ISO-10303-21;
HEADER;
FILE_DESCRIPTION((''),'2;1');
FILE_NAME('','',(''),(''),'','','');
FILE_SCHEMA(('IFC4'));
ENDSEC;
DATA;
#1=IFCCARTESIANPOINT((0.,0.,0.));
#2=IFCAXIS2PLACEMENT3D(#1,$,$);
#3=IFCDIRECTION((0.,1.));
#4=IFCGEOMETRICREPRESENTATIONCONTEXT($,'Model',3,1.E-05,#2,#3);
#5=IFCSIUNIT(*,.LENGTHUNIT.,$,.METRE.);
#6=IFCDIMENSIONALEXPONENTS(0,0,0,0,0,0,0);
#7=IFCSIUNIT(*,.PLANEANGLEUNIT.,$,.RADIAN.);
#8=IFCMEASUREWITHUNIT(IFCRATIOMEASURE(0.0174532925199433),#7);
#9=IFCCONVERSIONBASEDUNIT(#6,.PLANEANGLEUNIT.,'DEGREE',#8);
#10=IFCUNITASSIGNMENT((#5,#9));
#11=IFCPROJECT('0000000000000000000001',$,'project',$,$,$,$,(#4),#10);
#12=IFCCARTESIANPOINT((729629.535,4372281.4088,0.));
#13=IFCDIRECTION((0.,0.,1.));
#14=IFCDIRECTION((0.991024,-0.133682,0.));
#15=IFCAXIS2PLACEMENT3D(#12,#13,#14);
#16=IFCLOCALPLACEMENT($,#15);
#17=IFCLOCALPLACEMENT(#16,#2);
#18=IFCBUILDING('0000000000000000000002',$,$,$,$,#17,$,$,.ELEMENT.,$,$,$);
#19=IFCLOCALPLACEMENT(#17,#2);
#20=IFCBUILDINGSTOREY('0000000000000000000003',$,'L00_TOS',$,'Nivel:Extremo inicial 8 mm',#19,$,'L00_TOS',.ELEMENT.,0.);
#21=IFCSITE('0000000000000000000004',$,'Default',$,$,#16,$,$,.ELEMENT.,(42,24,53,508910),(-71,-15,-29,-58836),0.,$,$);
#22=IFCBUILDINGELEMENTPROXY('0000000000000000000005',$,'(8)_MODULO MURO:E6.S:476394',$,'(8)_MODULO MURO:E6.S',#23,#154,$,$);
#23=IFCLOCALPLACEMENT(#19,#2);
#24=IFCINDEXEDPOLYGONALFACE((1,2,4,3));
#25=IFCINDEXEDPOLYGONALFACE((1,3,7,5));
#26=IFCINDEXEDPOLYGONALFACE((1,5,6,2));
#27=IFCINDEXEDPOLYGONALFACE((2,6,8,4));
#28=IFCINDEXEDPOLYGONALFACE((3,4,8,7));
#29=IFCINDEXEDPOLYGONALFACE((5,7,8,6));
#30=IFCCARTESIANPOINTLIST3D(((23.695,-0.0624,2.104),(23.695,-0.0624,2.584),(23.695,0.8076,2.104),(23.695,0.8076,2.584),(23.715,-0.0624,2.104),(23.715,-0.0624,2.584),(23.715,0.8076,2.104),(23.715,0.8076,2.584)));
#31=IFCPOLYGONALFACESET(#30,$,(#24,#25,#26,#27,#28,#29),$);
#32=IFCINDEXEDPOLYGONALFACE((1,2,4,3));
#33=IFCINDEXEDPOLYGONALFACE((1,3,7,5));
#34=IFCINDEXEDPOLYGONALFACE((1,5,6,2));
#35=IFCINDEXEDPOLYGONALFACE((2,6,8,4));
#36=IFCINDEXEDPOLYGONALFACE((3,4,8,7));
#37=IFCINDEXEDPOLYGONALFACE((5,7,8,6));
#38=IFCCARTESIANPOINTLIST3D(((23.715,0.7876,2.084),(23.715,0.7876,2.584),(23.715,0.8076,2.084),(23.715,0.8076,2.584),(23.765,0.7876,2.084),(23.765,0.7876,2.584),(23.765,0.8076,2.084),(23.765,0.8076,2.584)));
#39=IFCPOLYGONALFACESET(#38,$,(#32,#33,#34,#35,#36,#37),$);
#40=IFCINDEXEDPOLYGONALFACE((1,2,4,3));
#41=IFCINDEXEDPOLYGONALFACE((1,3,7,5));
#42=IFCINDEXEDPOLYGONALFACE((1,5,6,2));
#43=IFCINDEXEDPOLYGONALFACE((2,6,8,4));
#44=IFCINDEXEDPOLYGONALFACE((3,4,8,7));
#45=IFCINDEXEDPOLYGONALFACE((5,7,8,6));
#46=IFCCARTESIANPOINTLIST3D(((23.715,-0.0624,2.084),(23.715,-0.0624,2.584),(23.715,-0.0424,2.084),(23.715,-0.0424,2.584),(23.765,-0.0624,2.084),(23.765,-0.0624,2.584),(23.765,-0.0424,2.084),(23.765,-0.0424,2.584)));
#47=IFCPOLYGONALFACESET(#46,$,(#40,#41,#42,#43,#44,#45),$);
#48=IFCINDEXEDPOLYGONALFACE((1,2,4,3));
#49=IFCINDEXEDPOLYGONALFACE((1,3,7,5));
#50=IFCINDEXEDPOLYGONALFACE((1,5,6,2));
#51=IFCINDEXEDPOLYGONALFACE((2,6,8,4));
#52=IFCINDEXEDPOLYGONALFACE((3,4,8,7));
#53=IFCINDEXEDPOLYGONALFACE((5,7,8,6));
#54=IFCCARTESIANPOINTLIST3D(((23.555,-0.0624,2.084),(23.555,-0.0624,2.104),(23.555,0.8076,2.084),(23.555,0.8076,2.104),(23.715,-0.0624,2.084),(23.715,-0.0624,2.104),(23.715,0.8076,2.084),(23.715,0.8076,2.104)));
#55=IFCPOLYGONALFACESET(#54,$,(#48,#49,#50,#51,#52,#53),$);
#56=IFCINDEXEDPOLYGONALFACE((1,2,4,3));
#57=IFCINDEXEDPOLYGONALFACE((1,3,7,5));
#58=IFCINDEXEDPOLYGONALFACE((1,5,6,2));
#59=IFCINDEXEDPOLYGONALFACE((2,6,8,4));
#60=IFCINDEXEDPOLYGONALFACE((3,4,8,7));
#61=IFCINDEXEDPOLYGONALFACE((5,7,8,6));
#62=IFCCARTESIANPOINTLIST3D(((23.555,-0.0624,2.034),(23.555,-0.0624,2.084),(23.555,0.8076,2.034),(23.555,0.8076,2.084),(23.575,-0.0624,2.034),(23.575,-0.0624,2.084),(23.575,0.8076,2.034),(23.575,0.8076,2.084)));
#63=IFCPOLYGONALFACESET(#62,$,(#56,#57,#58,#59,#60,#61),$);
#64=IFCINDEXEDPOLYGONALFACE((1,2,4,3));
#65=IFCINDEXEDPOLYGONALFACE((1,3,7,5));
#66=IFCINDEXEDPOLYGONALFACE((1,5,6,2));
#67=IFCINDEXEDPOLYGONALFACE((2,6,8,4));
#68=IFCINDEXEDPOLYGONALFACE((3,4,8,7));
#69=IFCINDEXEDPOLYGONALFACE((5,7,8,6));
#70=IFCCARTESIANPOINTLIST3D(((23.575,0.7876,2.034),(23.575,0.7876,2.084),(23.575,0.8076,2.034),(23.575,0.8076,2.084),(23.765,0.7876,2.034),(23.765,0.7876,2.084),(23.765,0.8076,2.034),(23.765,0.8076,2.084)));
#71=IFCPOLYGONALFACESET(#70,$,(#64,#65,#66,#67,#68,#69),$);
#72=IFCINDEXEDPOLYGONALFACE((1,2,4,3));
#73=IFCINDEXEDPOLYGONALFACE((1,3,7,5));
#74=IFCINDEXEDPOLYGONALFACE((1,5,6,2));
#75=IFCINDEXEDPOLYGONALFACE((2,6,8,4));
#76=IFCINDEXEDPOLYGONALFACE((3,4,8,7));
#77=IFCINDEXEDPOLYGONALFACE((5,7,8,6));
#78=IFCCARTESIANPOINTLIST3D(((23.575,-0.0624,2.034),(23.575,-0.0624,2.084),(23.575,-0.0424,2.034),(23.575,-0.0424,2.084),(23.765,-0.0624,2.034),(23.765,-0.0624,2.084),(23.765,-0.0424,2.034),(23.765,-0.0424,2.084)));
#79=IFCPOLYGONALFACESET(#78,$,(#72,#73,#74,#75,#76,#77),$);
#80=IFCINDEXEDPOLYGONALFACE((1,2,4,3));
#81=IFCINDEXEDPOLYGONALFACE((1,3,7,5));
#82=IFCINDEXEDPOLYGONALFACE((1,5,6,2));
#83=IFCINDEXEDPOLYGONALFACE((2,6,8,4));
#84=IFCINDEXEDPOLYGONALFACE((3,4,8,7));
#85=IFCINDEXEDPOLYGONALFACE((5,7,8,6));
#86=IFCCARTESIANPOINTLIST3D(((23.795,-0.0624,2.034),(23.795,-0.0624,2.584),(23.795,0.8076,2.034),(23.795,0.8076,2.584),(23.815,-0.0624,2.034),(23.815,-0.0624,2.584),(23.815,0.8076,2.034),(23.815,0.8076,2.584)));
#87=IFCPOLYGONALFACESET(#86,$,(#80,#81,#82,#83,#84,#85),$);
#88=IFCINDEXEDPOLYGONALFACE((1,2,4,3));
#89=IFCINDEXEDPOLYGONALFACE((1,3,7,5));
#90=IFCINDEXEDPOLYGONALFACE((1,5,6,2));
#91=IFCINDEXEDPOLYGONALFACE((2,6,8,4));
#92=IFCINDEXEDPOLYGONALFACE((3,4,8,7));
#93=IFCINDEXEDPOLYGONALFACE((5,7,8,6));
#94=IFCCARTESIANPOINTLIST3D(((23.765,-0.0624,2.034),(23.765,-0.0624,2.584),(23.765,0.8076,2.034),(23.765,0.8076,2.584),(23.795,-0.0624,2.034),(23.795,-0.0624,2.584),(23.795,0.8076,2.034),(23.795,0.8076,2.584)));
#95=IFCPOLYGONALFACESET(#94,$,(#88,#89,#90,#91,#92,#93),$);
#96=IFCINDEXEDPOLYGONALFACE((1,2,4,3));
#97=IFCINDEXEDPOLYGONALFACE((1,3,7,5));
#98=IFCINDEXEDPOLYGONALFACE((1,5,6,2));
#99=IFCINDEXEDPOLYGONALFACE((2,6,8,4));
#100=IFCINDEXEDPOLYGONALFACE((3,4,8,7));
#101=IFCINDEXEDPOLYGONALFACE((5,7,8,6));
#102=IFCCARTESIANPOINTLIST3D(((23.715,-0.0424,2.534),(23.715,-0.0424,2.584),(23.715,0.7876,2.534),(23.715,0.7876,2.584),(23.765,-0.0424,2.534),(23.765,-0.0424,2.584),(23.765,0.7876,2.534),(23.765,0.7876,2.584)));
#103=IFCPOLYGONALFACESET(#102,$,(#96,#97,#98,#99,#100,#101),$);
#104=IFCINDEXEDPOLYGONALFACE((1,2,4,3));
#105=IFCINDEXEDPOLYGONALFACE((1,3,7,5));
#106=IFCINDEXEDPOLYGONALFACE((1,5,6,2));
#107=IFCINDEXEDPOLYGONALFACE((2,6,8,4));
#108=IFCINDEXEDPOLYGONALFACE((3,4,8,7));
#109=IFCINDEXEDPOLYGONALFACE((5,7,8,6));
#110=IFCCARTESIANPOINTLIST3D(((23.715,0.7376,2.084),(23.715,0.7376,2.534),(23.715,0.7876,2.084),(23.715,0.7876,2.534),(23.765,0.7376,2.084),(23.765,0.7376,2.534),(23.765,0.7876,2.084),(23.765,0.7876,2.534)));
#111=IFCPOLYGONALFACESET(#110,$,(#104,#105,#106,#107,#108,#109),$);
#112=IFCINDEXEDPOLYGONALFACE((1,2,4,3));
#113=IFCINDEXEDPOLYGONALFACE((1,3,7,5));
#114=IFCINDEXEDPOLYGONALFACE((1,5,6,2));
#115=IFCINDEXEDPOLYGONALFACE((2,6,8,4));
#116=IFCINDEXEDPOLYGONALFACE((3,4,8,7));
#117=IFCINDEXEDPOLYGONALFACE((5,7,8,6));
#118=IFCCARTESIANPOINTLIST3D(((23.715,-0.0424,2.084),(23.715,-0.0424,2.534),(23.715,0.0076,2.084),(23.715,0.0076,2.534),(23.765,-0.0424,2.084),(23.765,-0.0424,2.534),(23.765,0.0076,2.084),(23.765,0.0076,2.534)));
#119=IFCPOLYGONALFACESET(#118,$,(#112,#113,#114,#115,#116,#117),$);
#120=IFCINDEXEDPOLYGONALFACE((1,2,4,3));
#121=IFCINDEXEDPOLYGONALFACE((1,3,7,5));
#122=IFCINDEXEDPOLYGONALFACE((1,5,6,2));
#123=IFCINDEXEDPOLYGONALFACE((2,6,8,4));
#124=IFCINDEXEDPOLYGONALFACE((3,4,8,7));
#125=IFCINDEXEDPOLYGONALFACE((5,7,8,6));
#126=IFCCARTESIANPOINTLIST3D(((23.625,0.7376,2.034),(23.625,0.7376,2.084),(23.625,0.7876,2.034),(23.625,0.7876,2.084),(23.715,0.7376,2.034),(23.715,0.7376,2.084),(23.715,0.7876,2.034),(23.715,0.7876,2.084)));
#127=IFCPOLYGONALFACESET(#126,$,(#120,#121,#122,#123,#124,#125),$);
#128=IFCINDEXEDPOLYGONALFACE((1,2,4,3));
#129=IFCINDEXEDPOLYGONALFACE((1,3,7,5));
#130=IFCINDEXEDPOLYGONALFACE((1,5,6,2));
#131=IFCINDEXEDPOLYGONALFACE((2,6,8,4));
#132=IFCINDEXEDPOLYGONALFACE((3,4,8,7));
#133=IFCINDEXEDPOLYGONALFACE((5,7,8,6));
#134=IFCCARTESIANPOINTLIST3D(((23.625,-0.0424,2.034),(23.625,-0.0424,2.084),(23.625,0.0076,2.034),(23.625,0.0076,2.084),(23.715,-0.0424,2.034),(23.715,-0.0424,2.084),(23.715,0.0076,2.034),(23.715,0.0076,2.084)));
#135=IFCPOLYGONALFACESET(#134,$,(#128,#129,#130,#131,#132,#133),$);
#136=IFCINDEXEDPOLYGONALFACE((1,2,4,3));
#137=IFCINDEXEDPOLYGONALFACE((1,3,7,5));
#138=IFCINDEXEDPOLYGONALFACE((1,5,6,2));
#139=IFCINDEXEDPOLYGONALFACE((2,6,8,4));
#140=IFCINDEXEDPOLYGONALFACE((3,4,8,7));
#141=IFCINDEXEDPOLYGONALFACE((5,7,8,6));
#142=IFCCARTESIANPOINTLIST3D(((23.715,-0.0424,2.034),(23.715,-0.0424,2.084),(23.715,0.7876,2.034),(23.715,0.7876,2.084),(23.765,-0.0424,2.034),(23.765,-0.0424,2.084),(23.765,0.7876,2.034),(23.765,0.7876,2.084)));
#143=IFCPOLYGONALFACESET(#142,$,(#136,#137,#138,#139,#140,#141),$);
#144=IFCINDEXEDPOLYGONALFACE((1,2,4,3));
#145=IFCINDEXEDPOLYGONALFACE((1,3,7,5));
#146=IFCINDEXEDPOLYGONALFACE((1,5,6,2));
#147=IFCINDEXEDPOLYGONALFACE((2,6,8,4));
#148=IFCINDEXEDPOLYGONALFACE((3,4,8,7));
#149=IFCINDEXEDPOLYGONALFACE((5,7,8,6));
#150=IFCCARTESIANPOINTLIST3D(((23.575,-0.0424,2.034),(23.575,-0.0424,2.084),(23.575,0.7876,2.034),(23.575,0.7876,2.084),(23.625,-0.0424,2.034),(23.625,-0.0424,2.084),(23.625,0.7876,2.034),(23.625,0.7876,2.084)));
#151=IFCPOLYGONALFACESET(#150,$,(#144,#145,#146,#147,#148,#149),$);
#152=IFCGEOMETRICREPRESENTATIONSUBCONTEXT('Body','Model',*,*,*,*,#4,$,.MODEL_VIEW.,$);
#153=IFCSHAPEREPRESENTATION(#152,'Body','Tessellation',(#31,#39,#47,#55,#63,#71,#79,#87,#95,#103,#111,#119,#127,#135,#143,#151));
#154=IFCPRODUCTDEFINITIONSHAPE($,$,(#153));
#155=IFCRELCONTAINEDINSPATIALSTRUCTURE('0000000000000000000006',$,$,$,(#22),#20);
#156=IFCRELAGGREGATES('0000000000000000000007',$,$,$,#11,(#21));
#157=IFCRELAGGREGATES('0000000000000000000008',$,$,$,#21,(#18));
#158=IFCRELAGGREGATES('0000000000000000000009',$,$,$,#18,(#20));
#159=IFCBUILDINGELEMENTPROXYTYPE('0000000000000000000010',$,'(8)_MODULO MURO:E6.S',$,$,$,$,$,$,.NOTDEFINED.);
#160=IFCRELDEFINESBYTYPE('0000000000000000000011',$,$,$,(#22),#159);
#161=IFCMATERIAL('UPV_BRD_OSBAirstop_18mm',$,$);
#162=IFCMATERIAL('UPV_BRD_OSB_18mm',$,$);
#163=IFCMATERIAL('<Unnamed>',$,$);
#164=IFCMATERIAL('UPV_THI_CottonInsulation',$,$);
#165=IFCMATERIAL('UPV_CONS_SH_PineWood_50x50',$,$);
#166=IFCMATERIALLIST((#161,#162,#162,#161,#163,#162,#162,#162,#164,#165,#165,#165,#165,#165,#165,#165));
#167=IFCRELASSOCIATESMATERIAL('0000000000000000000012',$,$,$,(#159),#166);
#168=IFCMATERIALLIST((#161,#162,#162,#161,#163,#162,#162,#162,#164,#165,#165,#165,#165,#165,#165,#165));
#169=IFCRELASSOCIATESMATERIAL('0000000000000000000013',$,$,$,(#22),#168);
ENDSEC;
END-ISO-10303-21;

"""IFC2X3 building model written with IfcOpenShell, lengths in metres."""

from ifc_helpers import new_model, entity, si_unit, converted_unit, direction, frame, frame_2d, origin, origin_2d_with_axis, place, context, subcontext, project, spatial, rectangle, extrude, source, transform, mapped, material, material_list, type_object, type_shapes, element, save


model = new_model("IFC2X3")

# Units and contexts
model_context = context("Model", 3, precision=1e-05, world=origin(), true_north=direction((0.0, 1.0)))
body_context = subcontext(model_context, "Body", "Model", "MODEL_VIEW")
ifc_project = project(units=[si_unit("LENGTHUNIT", "METRE"), converted_unit("PLANEANGLEUNIT", "DEGREE", entity("IfcRatioMeasure", 0.0174532925199433), si_unit("PLANEANGLEUNIT", "RADIAN"), dimensions=[0, 0, 0, 0, 0, 0, 0])], contexts=[model_context])

# Site, building, storey
site_placement = place(None, frame((729629.535, 4372281.4088, 0.0), z_axis=(0.0, 0.0, 1.0), x_axis=(0.991024, -0.133682, 0.0)))
site = spatial("IfcSite", under=ifc_project, at=site_placement, Name="Default", CompositionType="ELEMENT", RefLatitude=(42, 24, 53, 508910), RefLongitude=(-71, -15, -29, -58836), RefElevation=0.0)
building_placement = place(site_placement, origin())
building = spatial("IfcBuilding", under=site, at=building_placement, CompositionType="ELEMENT")
storey_placement = place(building_placement, origin())
storey = spatial("IfcBuildingStorey", under=building, at=storey_placement, Name="L00_TOS", ObjectType="Nivel:Extremo inicial 8 mm", LongName="L00_TOS", CompositionType="ELEMENT", Elevation=0.0)

# Building element proxy
ifc_material_1 = material(Name="UPV_BRD_OSBAirstop_18mm")
ifc_material_2 = material(Name="UPV_BRD_OSB_18mm")
ifc_material_3 = material(Name="UPV_THI_CottonInsulation")
ifc_material_4 = material(Name="<Unnamed>")
ifc_material_5 = material(Name="UPV_CONS_SH_PineWood_50x50")
ifc_material_list_1 = material_list([ifc_material_1, ifc_material_2, ifc_material_2, ifc_material_1, ifc_material_4, ifc_material_2, ifc_material_2, ifc_material_2, ifc_material_3, ifc_material_5, ifc_material_5, ifc_material_5, ifc_material_5, ifc_material_5, ifc_material_5, ifc_material_5])
ifc_material_list_2 = material_list([ifc_material_1, ifc_material_2, ifc_material_2, ifc_material_1, ifc_material_4, ifc_material_2, ifc_material_2, ifc_material_2, ifc_material_3, ifc_material_5, ifc_material_5, ifc_material_5, ifc_material_5, ifc_material_5, ifc_material_5, ifc_material_5])
building_element_proxy_type_1 = type_object("IfcBuildingElementProxyType", Name="(8)_MODULO MURO:E6.S", PredefinedType="NOTDEFINED", material=ifc_material_list_2)
shared_shape_1 = source(origin(), body_context, "Body", "SweptSolid", [
    extrude(rectangle(XDim=0.87, YDim=0.02, at=frame_2d((0.0, 0.0), x_axis=(1.0, 0.0))), frame((0.0, 0.035, 0.07), z_axis=(0.0, 0.0, 1.0), x_axis=(-1.0, 0.0, 0.0)), (0.0, 0.0, 1.0), 0.48),
    extrude(rectangle(XDim=0.05, YDim=0.02, at=frame_2d((0.0, 0.0), x_axis=(1.0, 0.0))), frame((-0.425, 0.07, 0.05), z_axis=(0.0, 0.0, 1.0), x_axis=(0.0, -1.0, 0.0)), (0.0, 0.0, 1.0), 0.5),
    extrude(rectangle(XDim=0.05, YDim=0.02, at=origin_2d_with_axis()), frame((0.425, 0.07, 0.05), z_axis=(0.0, 0.0, 1.0), x_axis=(0.0, -1.0, 0.0)), (0.0, 0.0, 1.0), 0.5),
    extrude(rectangle(XDim=0.87, YDim=0.16, at=origin_2d_with_axis()), frame((0.0, -0.035, 0.05)), (0.0, 0.0, 1.0), 0.02),
    extrude(rectangle(XDim=0.87, YDim=0.02, at=origin_2d_with_axis()), frame((0.0, -0.105, 0.0), z_axis=(0.0, 0.0, 1.0), x_axis=(-1.0, 0.0, 0.0)), (0.0, 0.0, 1.0), 0.05),
    extrude(rectangle(XDim=0.19, YDim=0.02, at=frame_2d((0.0, 0.0), x_axis=(1.0, 0.0))), frame((-0.425, 0.0, 0.0), z_axis=(0.0, 0.0, 1.0), x_axis=(0.0, -1.0, 0.0)), (0.0, 0.0, 1.0), 0.05),
    extrude(rectangle(XDim=0.19, YDim=0.02, at=origin_2d_with_axis()), frame((0.425, 0.0, 0.0), z_axis=(0.0, 0.0, 1.0), x_axis=(0.0, -1.0, 0.0)), (0.0, 0.0, 1.0), 0.05),
    extrude(rectangle(XDim=0.87, YDim=0.02, at=frame_2d((0.0, 0.0), x_axis=(1.0, 0.0))), frame((0.0, 0.135, 0.0), z_axis=(0.0, 0.0, 1.0), x_axis=(-1.0, 0.0, 0.0)), (0.0, 0.0, 1.0), 0.55),
    extrude(rectangle(XDim=0.87, YDim=0.03, at=origin_2d_with_axis()), frame((0.0, 0.11, 0.0)), (0.0, 0.0, 1.0), 0.55),
    extrude(rectangle(XDim=0.05, YDim=0.83, at=origin_2d_with_axis()), frame((0.0, 0.07, 0.5), z_axis=(0.0, 0.0, 1.0), x_axis=(0.0, -1.0, 0.0)), (0.0, 0.0, 1.0), 0.05),
    extrude(rectangle(XDim=0.05, YDim=0.05, at=origin_2d_with_axis()), frame((-0.39, 0.07, 0.05)), (0.0, 0.0, 1.0), 0.45),
    extrude(rectangle(XDim=0.05, YDim=0.05, at=origin_2d_with_axis()), frame((0.39, 0.07, 0.05), z_axis=(0.0, 0.0, 1.0), x_axis=(0.0, -1.0, 0.0)), (0.0, 0.0, 1.0), 0.45),
    extrude(rectangle(XDim=0.09, YDim=0.05, at=origin_2d_with_axis()), frame((-0.39, 0.0, 0.0), z_axis=(0.0, 0.0, 1.0), x_axis=(0.0, -1.0, 0.0)), (0.0, 0.0, 1.0), 0.05),
    extrude(rectangle(XDim=0.09, YDim=0.05, at=origin_2d_with_axis()), frame((0.39, 0.0, 0.0), z_axis=(0.0, 0.0, 1.0), x_axis=(0.0, -1.0, 0.0)), (0.0, 0.0, 1.0), 0.05),
    extrude(rectangle(XDim=0.05, YDim=0.83, at=origin_2d_with_axis()), frame((0.0, 0.07, 0.0), z_axis=(0.0, 0.0, 1.0), x_axis=(0.0, -1.0, 0.0)), (0.0, 0.0, 1.0), 0.05),
    extrude(rectangle(XDim=0.05, YDim=0.83, at=origin_2d_with_axis()), frame((0.0, -0.07, 0.0), z_axis=(0.0, 0.0, 1.0), x_axis=(0.0, -1.0, 0.0)), (0.0, 0.0, 1.0), 0.05),
])
type_shapes(building_element_proxy_type_1, [shared_shape_1])
proxy_1_placement = place(storey_placement, frame((23.67, 0.3726, 2.034), z_axis=(0.0, 0.0, 1.0), x_axis=(0.0, -1.0, 0.0)))
element("IfcBuildingElementProxy", 1, at=proxy_1_placement, inside=storey, type_object=building_element_proxy_type_1, material=ifc_material_list_1, Name="(8)_MODULO MURO:E6.S:476394", ObjectType="(8)_MODULO MURO:E6.S", context=body_context, shape_type="MappedRepresentation", body=[
    mapped(shared_shape_1, transform((0.0, 0.0, 0.0), scale=1.0)),
])

save(model, "model.ifc")
